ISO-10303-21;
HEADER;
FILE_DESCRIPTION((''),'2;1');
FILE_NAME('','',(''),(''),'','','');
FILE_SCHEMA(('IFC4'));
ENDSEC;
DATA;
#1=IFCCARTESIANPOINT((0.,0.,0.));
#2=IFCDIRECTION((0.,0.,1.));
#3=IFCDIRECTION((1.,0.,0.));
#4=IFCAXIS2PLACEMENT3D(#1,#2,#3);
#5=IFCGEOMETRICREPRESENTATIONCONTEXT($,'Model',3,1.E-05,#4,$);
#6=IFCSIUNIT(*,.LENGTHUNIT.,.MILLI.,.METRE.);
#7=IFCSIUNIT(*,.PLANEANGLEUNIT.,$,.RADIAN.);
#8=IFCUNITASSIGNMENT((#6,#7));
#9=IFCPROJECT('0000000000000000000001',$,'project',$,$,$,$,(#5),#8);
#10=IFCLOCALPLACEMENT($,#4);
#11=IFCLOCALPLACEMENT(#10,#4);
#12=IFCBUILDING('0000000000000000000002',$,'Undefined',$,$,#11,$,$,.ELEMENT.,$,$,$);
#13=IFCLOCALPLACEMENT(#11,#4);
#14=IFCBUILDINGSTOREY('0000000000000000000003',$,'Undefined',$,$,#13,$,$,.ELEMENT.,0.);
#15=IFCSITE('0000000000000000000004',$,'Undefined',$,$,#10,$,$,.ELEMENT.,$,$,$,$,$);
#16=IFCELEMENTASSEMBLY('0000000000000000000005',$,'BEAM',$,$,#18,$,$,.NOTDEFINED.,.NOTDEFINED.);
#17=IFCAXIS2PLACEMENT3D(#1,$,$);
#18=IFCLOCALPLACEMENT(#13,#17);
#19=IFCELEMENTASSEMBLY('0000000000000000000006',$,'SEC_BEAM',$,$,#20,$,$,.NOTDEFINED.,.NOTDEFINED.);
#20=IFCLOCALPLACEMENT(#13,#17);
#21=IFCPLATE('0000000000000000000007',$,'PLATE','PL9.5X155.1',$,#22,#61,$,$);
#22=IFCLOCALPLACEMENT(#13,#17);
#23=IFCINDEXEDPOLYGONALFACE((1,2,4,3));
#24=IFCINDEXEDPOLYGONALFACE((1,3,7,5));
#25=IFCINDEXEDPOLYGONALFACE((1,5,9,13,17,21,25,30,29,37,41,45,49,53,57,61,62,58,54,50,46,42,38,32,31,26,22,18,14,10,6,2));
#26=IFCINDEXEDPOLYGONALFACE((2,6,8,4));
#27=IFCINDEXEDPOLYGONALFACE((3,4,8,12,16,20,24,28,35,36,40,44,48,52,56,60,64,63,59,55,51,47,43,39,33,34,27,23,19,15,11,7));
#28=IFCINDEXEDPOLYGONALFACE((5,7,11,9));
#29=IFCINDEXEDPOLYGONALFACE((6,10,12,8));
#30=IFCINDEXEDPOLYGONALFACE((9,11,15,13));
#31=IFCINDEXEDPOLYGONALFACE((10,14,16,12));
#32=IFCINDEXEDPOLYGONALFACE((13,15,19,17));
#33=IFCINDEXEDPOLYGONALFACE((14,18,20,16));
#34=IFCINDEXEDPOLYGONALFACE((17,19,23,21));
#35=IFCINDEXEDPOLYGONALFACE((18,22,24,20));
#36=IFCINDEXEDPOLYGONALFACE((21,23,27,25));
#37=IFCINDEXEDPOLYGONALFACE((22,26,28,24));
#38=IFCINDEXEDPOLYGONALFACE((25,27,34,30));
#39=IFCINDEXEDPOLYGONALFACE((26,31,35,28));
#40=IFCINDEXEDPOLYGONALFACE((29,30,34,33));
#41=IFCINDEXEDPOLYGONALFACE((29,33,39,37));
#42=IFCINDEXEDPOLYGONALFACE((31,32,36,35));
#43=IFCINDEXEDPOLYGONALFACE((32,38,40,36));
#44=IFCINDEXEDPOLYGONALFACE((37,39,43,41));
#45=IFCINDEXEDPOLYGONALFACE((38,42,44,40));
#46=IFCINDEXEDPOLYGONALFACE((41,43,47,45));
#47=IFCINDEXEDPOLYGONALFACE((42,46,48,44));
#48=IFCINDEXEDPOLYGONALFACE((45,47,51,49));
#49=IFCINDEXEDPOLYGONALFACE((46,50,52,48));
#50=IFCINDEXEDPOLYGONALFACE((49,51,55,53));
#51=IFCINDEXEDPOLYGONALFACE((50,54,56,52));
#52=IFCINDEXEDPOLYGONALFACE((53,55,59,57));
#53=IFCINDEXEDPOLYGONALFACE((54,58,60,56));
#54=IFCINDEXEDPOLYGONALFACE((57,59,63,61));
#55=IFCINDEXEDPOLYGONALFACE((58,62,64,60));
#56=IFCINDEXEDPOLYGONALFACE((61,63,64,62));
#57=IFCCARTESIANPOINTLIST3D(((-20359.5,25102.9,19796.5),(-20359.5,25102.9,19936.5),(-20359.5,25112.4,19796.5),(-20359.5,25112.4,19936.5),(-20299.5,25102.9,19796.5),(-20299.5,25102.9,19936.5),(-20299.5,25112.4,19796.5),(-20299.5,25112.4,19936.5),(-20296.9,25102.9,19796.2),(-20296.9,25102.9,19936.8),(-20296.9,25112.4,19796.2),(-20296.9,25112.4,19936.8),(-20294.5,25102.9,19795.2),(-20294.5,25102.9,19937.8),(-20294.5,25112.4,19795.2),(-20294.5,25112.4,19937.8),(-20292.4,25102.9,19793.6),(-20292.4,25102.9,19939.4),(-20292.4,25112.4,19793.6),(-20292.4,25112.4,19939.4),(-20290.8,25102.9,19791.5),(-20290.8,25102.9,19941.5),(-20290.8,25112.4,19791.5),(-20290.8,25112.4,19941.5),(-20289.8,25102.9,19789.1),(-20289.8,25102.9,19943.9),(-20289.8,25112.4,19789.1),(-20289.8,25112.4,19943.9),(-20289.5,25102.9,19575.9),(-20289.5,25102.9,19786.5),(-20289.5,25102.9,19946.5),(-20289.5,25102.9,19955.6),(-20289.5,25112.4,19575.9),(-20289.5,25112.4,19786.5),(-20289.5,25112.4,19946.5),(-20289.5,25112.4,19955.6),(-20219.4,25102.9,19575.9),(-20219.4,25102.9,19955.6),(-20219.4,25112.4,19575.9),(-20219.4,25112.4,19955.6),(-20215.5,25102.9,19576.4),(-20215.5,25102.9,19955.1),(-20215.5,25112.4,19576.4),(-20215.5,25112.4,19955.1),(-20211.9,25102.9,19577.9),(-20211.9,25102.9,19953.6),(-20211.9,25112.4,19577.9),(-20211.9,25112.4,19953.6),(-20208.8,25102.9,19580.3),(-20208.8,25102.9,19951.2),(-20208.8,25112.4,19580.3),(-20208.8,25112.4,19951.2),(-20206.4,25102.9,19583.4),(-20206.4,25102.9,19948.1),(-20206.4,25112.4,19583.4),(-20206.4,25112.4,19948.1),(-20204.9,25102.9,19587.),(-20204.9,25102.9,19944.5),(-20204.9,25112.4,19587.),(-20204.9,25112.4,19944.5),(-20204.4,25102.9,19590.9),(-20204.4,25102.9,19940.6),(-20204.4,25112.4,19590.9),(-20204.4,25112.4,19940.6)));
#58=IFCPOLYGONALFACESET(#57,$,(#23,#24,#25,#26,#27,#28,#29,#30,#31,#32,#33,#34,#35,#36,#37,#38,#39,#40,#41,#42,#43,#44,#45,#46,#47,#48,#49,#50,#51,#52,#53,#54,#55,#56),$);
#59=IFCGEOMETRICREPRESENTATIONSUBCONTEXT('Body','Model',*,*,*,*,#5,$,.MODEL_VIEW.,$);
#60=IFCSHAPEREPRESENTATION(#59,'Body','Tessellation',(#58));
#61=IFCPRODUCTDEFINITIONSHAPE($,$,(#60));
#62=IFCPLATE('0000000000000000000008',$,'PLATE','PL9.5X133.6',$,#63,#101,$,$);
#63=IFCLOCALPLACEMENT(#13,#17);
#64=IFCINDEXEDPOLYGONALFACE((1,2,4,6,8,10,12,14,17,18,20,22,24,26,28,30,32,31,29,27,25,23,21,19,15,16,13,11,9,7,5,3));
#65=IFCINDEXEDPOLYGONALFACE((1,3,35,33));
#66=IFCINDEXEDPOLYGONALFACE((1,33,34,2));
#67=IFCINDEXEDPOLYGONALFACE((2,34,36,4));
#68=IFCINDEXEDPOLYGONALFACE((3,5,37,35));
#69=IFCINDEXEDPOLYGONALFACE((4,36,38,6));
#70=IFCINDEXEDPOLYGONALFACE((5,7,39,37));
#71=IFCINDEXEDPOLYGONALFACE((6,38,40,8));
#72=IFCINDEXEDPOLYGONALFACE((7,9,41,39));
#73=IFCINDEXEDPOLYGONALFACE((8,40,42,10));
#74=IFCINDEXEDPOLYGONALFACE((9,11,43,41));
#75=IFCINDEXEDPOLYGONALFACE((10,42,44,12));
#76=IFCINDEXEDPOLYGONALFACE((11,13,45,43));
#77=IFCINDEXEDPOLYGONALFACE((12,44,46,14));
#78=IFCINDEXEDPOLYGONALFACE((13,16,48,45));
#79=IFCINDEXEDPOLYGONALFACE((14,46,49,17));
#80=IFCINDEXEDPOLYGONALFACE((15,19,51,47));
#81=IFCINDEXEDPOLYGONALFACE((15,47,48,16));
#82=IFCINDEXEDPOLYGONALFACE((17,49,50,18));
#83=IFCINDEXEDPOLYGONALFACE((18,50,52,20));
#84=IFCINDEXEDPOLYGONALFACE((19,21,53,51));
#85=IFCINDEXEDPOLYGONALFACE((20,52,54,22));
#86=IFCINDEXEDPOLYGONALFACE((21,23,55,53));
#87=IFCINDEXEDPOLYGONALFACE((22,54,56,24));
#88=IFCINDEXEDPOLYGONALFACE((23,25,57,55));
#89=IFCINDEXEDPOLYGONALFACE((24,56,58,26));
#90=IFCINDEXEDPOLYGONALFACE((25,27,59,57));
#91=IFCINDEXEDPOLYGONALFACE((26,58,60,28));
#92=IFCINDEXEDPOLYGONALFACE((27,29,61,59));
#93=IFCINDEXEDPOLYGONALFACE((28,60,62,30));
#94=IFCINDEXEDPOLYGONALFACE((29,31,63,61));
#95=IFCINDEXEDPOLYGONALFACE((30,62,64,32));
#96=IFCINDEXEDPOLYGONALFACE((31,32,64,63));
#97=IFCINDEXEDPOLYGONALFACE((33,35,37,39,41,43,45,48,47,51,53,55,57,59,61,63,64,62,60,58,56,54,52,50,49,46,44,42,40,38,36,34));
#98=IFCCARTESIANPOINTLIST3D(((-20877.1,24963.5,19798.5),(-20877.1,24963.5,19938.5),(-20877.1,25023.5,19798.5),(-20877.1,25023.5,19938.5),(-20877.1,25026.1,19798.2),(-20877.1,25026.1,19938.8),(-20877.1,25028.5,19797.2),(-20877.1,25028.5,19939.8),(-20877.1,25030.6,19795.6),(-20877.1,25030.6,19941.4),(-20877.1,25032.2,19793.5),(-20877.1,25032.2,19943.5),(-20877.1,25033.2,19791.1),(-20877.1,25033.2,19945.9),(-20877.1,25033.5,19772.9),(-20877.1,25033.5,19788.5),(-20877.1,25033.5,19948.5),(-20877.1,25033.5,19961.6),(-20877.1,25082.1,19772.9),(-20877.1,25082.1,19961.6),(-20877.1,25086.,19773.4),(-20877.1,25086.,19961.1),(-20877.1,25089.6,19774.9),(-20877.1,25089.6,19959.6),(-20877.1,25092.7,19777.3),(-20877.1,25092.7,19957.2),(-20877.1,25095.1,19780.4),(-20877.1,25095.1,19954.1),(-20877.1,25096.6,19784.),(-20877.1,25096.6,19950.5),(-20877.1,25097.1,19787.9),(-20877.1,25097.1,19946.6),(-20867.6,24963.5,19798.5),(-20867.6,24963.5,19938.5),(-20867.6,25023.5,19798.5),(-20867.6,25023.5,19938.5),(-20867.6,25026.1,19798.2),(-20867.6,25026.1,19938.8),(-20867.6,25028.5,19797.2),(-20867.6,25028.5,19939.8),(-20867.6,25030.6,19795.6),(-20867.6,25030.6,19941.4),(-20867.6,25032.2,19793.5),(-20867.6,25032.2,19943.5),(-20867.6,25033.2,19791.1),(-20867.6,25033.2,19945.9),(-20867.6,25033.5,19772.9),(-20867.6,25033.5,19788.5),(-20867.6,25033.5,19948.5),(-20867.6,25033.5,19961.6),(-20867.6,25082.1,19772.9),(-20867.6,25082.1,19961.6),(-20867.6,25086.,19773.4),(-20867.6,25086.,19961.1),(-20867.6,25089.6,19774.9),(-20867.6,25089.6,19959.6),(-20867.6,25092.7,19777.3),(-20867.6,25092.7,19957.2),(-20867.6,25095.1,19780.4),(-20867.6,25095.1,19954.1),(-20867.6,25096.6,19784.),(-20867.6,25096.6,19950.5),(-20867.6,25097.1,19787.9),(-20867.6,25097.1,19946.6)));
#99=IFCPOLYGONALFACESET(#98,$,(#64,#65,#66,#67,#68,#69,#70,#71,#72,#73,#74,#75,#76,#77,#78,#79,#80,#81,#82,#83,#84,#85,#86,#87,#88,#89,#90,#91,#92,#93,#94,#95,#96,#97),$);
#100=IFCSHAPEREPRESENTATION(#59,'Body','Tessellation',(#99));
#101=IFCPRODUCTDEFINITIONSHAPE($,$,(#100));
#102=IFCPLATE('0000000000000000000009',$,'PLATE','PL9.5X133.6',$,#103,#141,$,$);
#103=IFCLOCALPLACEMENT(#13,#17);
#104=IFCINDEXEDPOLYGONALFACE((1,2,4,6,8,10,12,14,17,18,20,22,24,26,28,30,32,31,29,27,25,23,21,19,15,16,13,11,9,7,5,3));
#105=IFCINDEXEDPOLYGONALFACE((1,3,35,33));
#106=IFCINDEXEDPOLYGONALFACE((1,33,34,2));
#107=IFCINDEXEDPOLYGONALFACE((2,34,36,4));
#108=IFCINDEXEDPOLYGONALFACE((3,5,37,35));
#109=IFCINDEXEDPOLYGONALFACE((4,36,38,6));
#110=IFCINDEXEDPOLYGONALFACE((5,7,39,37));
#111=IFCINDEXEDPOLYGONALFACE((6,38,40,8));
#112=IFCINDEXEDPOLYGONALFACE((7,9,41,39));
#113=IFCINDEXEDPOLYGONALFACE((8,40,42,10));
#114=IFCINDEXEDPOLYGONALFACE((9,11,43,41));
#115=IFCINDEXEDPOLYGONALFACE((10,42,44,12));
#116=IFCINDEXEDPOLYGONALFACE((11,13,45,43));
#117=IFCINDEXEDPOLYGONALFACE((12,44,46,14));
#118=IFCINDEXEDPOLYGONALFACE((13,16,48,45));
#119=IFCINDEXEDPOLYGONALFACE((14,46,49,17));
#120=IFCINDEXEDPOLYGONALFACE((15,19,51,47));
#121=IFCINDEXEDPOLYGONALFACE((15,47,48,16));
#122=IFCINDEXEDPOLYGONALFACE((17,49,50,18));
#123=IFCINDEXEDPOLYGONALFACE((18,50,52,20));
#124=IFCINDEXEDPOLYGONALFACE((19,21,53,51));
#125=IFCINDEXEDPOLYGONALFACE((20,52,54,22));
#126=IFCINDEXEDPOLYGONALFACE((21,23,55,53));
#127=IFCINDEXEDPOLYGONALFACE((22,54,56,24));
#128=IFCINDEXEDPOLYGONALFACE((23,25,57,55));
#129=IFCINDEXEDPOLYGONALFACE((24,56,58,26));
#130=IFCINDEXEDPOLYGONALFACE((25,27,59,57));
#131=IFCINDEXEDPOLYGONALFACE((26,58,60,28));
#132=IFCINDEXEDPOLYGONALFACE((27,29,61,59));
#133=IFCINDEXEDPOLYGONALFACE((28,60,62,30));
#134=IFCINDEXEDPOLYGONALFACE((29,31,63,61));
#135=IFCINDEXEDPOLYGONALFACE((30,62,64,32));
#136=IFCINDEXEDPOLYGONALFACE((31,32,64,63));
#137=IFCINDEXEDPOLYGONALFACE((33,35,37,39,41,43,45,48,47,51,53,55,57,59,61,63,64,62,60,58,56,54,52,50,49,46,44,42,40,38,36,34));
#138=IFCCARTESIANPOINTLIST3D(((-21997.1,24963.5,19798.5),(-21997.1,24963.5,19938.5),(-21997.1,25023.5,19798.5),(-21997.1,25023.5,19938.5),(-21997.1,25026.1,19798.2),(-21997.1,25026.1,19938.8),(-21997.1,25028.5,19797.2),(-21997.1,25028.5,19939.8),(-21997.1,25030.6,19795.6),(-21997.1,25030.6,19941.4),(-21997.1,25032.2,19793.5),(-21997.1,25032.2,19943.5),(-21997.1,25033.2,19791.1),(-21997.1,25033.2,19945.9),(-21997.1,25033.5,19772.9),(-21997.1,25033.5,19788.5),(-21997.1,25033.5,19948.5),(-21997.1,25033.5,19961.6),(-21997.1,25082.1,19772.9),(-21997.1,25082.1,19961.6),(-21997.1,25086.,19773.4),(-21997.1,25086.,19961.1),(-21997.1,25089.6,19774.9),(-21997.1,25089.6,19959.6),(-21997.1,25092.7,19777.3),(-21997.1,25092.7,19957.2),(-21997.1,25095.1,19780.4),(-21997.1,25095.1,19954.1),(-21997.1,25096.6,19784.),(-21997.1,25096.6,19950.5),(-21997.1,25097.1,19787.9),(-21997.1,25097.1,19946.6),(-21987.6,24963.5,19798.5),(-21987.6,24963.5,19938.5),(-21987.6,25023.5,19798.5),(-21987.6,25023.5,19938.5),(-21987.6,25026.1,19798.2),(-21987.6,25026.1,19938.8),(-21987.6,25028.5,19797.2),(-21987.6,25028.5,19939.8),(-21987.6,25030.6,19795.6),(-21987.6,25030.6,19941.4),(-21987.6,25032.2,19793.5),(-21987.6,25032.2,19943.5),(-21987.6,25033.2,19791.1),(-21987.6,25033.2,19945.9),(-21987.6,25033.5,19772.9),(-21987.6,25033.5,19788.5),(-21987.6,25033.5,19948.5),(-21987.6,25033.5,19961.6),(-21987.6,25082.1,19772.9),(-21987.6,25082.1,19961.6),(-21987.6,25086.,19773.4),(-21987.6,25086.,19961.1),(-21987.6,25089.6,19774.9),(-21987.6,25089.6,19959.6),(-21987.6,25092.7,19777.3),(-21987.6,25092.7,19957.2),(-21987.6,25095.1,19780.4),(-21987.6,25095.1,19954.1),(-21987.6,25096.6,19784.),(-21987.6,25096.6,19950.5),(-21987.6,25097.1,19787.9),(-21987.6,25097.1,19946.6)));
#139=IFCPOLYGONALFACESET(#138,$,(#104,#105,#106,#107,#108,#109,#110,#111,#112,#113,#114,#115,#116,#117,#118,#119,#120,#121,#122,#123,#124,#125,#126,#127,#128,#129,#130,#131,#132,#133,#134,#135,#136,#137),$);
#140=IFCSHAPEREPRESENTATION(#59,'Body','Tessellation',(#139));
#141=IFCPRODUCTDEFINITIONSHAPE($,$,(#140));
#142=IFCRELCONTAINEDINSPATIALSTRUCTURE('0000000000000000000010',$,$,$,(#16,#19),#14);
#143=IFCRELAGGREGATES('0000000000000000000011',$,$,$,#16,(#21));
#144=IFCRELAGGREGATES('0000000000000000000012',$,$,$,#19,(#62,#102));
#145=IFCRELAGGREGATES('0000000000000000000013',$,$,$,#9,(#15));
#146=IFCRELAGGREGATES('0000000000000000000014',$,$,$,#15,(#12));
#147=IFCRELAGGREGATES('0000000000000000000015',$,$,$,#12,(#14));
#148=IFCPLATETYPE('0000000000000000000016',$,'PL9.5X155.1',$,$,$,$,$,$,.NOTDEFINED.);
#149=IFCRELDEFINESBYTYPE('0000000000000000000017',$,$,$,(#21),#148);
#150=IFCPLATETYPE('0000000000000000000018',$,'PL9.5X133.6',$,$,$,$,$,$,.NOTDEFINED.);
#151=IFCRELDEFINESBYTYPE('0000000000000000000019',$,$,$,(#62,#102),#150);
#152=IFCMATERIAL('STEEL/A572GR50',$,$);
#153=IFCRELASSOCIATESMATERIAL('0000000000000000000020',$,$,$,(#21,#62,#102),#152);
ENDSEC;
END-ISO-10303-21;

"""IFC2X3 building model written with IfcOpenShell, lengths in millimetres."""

from ifc_helpers import new_model, si_unit, frame, frame_2d, origin_with_axes, place, context, subcontext, project, spatial, polyline, circle_curve, parameter, trimmed, segment, composite_curve, outline, extrude, material, type_object, element, aggregate, save


model = new_model("IFC2X3")

# Units and contexts
model_context = context("Model", 3, precision=1e-05, world=origin_with_axes())
body_context = subcontext(model_context, "Body", "Model", "MODEL_VIEW")
ifc_project = project(units=[si_unit("LENGTHUNIT", "METRE", prefix="MILLI"), si_unit("PLANEANGLEUNIT", "RADIAN")], contexts=[model_context])

# Site, building, storey
site_placement = place(None, origin_with_axes())
site = spatial("IfcSite", under=ifc_project, at=site_placement, Name="Undefined", CompositionType="ELEMENT")
building_placement = place(site_placement, origin_with_axes())
building = spatial("IfcBuilding", under=site, at=building_placement, Name="Undefined", CompositionType="ELEMENT")
storey_placement = place(building_placement, origin_with_axes())
storey = spatial("IfcBuildingStorey", under=building, at=storey_placement, Name="Undefined", CompositionType="ELEMENT", Elevation=0.0)

# Element assemblies
assembly_1_placement = place(storey_placement, origin_with_axes())
assembly_1 = element("IfcElementAssembly", 1, at=assembly_1_placement, inside=storey, Name="BEAM", AssemblyPlace="NOTDEFINED", PredefinedType="NOTDEFINED")
ifc_material_1 = material(Name="STEEL/A572GR50")
assembly_2_placement = place(storey_placement, origin_with_axes())
assembly_2 = element("IfcElementAssembly", 2, at=assembly_2_placement, inside=storey, Name="SEC_BEAM", AssemblyPlace="NOTDEFINED", PredefinedType="NOTDEFINED")

# Plates
plate_type_1 = type_object("IfcPlateType", Name="PL9.5X155.1", PredefinedType="NOTDEFINED")
plate_1_placement = place(assembly_1_placement, frame((-20204.4, 25107.7, 19955.6), z_axis=(0.0, 1.0, 0.0), x_axis=(0.0, 0.0, -1.0)))
plate_1 = element("IfcPlate", 3, at=plate_1_placement, type_object=plate_type_1, material=ifc_material_1, Name="PLATE", Description="PL9.5X155.1", context=body_context, shape_type="SweptSolid", body=[
    extrude(outline(composite_curve([segment(trimmed(circle_curve(frame_2d((15.0, 15.0), x_axis=(-1.0, 0.0)), 15.0), [parameter(0.0)], [parameter(1.570796)], True, "PARAMETER"), True, "CONTINUOUS"), segment(polyline([(15.0, 0.0), (364.7, 0.0)]), True, "CONTINUOUS"), segment(trimmed(circle_curve(frame_2d((364.7, 15.0), x_axis=(0.0, -1.0)), 15.0), [parameter(0.0)], [parameter(1.570796)], True, "PARAMETER"), True, "CONTINUOUS"), segment(polyline([(379.7, 15.0), (379.7, 85.1), (169.1, 85.1)]), True, "CONTINUOUS"), segment(trimmed(circle_curve(frame_2d((169.1, 95.1), x_axis=(0.0, -1.0)), 10.0), [parameter(0.0)], [parameter(4.712389)], False, "PARAMETER"), True, "CONTINUOUS"), segment(polyline([(159.1, 95.1), (159.1, 155.1), (19.1, 155.1), (19.1, 95.1)]), True, "CONTINUOUS"), segment(trimmed(circle_curve(frame_2d((9.1, 95.1), x_axis=(1.0, 0.0)), 10.0), [parameter(0.0)], [parameter(4.712389)], False, "PARAMETER"), True, "CONTINUOUS"), segment(polyline([(9.1, 85.1), (0.0, 85.1), (0.0, 15.0)]), True, "CONTINUOUS")], self_intersect=True)), frame((0.0, 0.0, -4.8), z_axis=(0.0, 0.0, 1.0), x_axis=(1.0, 0.0, 0.0)), (0.0, 0.0, 1.0), 9.5),
])
plate_type_2 = type_object("IfcPlateType", Name="PL9.5X133.6", PredefinedType="NOTDEFINED")
plate_2_placement = place(assembly_2_placement, frame((-20872.3, 25097.1, 19961.6), z_axis=(-1.0, 0.0, 0.0), x_axis=(0.0, 0.0, -1.0)))
plate_2 = element("IfcPlate", 4, at=plate_2_placement, type_object=plate_type_2, material=ifc_material_1, Name="PLATE", Description="PL9.5X133.6", context=body_context, shape_type="SweptSolid", body=[
    extrude(outline(composite_curve([segment(trimmed(circle_curve(frame_2d((15.0, 15.0), x_axis=(-1.0, 0.0)), 15.0), [parameter(0.0)], [parameter(1.570796)], True, "PARAMETER"), True, "CONTINUOUS"), segment(polyline([(15.0, 0.0), (173.7, 0.0)]), True, "CONTINUOUS"), segment(trimmed(circle_curve(frame_2d((173.7, 15.0), x_axis=(0.0, -1.0)), 15.0), [parameter(0.0)], [parameter(1.570796)], True, "PARAMETER"), True, "CONTINUOUS"), segment(polyline([(188.7, 15.0), (188.7, 63.6), (173.1, 63.6)]), True, "CONTINUOUS"), segment(trimmed(circle_curve(frame_2d((173.1, 73.6), x_axis=(0.0, -1.0)), 10.0), [parameter(0.0)], [parameter(4.712389)], False, "PARAMETER"), True, "CONTINUOUS"), segment(polyline([(163.1, 73.6), (163.1, 133.6), (23.1, 133.6), (23.1, 73.6)]), True, "CONTINUOUS"), segment(trimmed(circle_curve(frame_2d((13.1, 73.6), x_axis=(1.0, 0.0)), 10.0), [parameter(0.0)], [parameter(4.712389)], False, "PARAMETER"), True, "CONTINUOUS"), segment(polyline([(13.1, 63.6), (0.0, 63.6), (0.0, 15.0)]), True, "CONTINUOUS")], self_intersect=True)), frame((0.0, 0.0, -4.8), z_axis=(0.0, 0.0, 1.0), x_axis=(1.0, 0.0, 0.0)), (0.0, 0.0, 1.0), 9.5),
])
plate_3_placement = place(assembly_2_placement, frame((-21992.3, 25097.1, 19961.6), z_axis=(-1.0, 0.0, 0.0), x_axis=(0.0, 0.0, -1.0)))
plate_3 = element("IfcPlate", 5, at=plate_3_placement, type_object=plate_type_2, material=ifc_material_1, Name="PLATE", Description="PL9.5X133.6", context=body_context, shape_type="SweptSolid", body=[
    extrude(outline(composite_curve([segment(trimmed(circle_curve(frame_2d((15.0, 15.0), x_axis=(-1.0, 0.0)), 15.0), [parameter(0.0)], [parameter(1.570796)], True, "PARAMETER"), True, "CONTINUOUS"), segment(polyline([(15.0, 0.0), (173.7, 0.0)]), True, "CONTINUOUS"), segment(trimmed(circle_curve(frame_2d((173.7, 15.0), x_axis=(0.0, -1.0)), 15.0), [parameter(0.0)], [parameter(1.570796)], True, "PARAMETER"), True, "CONTINUOUS"), segment(polyline([(188.7, 15.0), (188.7, 63.6), (173.1, 63.6)]), True, "CONTINUOUS"), segment(trimmed(circle_curve(frame_2d((173.1, 73.6), x_axis=(0.0, -1.0)), 10.0), [parameter(0.0)], [parameter(4.712389)], False, "PARAMETER"), True, "CONTINUOUS"), segment(polyline([(163.1, 73.6), (163.1, 133.6), (23.1, 133.6), (23.1, 73.6)]), True, "CONTINUOUS"), segment(trimmed(circle_curve(frame_2d((13.1, 73.6), x_axis=(1.0, 0.0)), 10.0), [parameter(0.0)], [parameter(4.712389)], False, "PARAMETER"), True, "CONTINUOUS"), segment(polyline([(13.1, 63.6), (0.0, 63.6), (0.0, 15.0)]), True, "CONTINUOUS")], self_intersect=True)), frame((0.0, 0.0, -4.8), z_axis=(0.0, 0.0, 1.0), x_axis=(1.0, 0.0, 0.0)), (0.0, 0.0, 1.0), 9.5),
])

aggregate(assembly_1, [plate_1])
aggregate(assembly_2, [plate_2, plate_3])

save(model, "model.ifc")
